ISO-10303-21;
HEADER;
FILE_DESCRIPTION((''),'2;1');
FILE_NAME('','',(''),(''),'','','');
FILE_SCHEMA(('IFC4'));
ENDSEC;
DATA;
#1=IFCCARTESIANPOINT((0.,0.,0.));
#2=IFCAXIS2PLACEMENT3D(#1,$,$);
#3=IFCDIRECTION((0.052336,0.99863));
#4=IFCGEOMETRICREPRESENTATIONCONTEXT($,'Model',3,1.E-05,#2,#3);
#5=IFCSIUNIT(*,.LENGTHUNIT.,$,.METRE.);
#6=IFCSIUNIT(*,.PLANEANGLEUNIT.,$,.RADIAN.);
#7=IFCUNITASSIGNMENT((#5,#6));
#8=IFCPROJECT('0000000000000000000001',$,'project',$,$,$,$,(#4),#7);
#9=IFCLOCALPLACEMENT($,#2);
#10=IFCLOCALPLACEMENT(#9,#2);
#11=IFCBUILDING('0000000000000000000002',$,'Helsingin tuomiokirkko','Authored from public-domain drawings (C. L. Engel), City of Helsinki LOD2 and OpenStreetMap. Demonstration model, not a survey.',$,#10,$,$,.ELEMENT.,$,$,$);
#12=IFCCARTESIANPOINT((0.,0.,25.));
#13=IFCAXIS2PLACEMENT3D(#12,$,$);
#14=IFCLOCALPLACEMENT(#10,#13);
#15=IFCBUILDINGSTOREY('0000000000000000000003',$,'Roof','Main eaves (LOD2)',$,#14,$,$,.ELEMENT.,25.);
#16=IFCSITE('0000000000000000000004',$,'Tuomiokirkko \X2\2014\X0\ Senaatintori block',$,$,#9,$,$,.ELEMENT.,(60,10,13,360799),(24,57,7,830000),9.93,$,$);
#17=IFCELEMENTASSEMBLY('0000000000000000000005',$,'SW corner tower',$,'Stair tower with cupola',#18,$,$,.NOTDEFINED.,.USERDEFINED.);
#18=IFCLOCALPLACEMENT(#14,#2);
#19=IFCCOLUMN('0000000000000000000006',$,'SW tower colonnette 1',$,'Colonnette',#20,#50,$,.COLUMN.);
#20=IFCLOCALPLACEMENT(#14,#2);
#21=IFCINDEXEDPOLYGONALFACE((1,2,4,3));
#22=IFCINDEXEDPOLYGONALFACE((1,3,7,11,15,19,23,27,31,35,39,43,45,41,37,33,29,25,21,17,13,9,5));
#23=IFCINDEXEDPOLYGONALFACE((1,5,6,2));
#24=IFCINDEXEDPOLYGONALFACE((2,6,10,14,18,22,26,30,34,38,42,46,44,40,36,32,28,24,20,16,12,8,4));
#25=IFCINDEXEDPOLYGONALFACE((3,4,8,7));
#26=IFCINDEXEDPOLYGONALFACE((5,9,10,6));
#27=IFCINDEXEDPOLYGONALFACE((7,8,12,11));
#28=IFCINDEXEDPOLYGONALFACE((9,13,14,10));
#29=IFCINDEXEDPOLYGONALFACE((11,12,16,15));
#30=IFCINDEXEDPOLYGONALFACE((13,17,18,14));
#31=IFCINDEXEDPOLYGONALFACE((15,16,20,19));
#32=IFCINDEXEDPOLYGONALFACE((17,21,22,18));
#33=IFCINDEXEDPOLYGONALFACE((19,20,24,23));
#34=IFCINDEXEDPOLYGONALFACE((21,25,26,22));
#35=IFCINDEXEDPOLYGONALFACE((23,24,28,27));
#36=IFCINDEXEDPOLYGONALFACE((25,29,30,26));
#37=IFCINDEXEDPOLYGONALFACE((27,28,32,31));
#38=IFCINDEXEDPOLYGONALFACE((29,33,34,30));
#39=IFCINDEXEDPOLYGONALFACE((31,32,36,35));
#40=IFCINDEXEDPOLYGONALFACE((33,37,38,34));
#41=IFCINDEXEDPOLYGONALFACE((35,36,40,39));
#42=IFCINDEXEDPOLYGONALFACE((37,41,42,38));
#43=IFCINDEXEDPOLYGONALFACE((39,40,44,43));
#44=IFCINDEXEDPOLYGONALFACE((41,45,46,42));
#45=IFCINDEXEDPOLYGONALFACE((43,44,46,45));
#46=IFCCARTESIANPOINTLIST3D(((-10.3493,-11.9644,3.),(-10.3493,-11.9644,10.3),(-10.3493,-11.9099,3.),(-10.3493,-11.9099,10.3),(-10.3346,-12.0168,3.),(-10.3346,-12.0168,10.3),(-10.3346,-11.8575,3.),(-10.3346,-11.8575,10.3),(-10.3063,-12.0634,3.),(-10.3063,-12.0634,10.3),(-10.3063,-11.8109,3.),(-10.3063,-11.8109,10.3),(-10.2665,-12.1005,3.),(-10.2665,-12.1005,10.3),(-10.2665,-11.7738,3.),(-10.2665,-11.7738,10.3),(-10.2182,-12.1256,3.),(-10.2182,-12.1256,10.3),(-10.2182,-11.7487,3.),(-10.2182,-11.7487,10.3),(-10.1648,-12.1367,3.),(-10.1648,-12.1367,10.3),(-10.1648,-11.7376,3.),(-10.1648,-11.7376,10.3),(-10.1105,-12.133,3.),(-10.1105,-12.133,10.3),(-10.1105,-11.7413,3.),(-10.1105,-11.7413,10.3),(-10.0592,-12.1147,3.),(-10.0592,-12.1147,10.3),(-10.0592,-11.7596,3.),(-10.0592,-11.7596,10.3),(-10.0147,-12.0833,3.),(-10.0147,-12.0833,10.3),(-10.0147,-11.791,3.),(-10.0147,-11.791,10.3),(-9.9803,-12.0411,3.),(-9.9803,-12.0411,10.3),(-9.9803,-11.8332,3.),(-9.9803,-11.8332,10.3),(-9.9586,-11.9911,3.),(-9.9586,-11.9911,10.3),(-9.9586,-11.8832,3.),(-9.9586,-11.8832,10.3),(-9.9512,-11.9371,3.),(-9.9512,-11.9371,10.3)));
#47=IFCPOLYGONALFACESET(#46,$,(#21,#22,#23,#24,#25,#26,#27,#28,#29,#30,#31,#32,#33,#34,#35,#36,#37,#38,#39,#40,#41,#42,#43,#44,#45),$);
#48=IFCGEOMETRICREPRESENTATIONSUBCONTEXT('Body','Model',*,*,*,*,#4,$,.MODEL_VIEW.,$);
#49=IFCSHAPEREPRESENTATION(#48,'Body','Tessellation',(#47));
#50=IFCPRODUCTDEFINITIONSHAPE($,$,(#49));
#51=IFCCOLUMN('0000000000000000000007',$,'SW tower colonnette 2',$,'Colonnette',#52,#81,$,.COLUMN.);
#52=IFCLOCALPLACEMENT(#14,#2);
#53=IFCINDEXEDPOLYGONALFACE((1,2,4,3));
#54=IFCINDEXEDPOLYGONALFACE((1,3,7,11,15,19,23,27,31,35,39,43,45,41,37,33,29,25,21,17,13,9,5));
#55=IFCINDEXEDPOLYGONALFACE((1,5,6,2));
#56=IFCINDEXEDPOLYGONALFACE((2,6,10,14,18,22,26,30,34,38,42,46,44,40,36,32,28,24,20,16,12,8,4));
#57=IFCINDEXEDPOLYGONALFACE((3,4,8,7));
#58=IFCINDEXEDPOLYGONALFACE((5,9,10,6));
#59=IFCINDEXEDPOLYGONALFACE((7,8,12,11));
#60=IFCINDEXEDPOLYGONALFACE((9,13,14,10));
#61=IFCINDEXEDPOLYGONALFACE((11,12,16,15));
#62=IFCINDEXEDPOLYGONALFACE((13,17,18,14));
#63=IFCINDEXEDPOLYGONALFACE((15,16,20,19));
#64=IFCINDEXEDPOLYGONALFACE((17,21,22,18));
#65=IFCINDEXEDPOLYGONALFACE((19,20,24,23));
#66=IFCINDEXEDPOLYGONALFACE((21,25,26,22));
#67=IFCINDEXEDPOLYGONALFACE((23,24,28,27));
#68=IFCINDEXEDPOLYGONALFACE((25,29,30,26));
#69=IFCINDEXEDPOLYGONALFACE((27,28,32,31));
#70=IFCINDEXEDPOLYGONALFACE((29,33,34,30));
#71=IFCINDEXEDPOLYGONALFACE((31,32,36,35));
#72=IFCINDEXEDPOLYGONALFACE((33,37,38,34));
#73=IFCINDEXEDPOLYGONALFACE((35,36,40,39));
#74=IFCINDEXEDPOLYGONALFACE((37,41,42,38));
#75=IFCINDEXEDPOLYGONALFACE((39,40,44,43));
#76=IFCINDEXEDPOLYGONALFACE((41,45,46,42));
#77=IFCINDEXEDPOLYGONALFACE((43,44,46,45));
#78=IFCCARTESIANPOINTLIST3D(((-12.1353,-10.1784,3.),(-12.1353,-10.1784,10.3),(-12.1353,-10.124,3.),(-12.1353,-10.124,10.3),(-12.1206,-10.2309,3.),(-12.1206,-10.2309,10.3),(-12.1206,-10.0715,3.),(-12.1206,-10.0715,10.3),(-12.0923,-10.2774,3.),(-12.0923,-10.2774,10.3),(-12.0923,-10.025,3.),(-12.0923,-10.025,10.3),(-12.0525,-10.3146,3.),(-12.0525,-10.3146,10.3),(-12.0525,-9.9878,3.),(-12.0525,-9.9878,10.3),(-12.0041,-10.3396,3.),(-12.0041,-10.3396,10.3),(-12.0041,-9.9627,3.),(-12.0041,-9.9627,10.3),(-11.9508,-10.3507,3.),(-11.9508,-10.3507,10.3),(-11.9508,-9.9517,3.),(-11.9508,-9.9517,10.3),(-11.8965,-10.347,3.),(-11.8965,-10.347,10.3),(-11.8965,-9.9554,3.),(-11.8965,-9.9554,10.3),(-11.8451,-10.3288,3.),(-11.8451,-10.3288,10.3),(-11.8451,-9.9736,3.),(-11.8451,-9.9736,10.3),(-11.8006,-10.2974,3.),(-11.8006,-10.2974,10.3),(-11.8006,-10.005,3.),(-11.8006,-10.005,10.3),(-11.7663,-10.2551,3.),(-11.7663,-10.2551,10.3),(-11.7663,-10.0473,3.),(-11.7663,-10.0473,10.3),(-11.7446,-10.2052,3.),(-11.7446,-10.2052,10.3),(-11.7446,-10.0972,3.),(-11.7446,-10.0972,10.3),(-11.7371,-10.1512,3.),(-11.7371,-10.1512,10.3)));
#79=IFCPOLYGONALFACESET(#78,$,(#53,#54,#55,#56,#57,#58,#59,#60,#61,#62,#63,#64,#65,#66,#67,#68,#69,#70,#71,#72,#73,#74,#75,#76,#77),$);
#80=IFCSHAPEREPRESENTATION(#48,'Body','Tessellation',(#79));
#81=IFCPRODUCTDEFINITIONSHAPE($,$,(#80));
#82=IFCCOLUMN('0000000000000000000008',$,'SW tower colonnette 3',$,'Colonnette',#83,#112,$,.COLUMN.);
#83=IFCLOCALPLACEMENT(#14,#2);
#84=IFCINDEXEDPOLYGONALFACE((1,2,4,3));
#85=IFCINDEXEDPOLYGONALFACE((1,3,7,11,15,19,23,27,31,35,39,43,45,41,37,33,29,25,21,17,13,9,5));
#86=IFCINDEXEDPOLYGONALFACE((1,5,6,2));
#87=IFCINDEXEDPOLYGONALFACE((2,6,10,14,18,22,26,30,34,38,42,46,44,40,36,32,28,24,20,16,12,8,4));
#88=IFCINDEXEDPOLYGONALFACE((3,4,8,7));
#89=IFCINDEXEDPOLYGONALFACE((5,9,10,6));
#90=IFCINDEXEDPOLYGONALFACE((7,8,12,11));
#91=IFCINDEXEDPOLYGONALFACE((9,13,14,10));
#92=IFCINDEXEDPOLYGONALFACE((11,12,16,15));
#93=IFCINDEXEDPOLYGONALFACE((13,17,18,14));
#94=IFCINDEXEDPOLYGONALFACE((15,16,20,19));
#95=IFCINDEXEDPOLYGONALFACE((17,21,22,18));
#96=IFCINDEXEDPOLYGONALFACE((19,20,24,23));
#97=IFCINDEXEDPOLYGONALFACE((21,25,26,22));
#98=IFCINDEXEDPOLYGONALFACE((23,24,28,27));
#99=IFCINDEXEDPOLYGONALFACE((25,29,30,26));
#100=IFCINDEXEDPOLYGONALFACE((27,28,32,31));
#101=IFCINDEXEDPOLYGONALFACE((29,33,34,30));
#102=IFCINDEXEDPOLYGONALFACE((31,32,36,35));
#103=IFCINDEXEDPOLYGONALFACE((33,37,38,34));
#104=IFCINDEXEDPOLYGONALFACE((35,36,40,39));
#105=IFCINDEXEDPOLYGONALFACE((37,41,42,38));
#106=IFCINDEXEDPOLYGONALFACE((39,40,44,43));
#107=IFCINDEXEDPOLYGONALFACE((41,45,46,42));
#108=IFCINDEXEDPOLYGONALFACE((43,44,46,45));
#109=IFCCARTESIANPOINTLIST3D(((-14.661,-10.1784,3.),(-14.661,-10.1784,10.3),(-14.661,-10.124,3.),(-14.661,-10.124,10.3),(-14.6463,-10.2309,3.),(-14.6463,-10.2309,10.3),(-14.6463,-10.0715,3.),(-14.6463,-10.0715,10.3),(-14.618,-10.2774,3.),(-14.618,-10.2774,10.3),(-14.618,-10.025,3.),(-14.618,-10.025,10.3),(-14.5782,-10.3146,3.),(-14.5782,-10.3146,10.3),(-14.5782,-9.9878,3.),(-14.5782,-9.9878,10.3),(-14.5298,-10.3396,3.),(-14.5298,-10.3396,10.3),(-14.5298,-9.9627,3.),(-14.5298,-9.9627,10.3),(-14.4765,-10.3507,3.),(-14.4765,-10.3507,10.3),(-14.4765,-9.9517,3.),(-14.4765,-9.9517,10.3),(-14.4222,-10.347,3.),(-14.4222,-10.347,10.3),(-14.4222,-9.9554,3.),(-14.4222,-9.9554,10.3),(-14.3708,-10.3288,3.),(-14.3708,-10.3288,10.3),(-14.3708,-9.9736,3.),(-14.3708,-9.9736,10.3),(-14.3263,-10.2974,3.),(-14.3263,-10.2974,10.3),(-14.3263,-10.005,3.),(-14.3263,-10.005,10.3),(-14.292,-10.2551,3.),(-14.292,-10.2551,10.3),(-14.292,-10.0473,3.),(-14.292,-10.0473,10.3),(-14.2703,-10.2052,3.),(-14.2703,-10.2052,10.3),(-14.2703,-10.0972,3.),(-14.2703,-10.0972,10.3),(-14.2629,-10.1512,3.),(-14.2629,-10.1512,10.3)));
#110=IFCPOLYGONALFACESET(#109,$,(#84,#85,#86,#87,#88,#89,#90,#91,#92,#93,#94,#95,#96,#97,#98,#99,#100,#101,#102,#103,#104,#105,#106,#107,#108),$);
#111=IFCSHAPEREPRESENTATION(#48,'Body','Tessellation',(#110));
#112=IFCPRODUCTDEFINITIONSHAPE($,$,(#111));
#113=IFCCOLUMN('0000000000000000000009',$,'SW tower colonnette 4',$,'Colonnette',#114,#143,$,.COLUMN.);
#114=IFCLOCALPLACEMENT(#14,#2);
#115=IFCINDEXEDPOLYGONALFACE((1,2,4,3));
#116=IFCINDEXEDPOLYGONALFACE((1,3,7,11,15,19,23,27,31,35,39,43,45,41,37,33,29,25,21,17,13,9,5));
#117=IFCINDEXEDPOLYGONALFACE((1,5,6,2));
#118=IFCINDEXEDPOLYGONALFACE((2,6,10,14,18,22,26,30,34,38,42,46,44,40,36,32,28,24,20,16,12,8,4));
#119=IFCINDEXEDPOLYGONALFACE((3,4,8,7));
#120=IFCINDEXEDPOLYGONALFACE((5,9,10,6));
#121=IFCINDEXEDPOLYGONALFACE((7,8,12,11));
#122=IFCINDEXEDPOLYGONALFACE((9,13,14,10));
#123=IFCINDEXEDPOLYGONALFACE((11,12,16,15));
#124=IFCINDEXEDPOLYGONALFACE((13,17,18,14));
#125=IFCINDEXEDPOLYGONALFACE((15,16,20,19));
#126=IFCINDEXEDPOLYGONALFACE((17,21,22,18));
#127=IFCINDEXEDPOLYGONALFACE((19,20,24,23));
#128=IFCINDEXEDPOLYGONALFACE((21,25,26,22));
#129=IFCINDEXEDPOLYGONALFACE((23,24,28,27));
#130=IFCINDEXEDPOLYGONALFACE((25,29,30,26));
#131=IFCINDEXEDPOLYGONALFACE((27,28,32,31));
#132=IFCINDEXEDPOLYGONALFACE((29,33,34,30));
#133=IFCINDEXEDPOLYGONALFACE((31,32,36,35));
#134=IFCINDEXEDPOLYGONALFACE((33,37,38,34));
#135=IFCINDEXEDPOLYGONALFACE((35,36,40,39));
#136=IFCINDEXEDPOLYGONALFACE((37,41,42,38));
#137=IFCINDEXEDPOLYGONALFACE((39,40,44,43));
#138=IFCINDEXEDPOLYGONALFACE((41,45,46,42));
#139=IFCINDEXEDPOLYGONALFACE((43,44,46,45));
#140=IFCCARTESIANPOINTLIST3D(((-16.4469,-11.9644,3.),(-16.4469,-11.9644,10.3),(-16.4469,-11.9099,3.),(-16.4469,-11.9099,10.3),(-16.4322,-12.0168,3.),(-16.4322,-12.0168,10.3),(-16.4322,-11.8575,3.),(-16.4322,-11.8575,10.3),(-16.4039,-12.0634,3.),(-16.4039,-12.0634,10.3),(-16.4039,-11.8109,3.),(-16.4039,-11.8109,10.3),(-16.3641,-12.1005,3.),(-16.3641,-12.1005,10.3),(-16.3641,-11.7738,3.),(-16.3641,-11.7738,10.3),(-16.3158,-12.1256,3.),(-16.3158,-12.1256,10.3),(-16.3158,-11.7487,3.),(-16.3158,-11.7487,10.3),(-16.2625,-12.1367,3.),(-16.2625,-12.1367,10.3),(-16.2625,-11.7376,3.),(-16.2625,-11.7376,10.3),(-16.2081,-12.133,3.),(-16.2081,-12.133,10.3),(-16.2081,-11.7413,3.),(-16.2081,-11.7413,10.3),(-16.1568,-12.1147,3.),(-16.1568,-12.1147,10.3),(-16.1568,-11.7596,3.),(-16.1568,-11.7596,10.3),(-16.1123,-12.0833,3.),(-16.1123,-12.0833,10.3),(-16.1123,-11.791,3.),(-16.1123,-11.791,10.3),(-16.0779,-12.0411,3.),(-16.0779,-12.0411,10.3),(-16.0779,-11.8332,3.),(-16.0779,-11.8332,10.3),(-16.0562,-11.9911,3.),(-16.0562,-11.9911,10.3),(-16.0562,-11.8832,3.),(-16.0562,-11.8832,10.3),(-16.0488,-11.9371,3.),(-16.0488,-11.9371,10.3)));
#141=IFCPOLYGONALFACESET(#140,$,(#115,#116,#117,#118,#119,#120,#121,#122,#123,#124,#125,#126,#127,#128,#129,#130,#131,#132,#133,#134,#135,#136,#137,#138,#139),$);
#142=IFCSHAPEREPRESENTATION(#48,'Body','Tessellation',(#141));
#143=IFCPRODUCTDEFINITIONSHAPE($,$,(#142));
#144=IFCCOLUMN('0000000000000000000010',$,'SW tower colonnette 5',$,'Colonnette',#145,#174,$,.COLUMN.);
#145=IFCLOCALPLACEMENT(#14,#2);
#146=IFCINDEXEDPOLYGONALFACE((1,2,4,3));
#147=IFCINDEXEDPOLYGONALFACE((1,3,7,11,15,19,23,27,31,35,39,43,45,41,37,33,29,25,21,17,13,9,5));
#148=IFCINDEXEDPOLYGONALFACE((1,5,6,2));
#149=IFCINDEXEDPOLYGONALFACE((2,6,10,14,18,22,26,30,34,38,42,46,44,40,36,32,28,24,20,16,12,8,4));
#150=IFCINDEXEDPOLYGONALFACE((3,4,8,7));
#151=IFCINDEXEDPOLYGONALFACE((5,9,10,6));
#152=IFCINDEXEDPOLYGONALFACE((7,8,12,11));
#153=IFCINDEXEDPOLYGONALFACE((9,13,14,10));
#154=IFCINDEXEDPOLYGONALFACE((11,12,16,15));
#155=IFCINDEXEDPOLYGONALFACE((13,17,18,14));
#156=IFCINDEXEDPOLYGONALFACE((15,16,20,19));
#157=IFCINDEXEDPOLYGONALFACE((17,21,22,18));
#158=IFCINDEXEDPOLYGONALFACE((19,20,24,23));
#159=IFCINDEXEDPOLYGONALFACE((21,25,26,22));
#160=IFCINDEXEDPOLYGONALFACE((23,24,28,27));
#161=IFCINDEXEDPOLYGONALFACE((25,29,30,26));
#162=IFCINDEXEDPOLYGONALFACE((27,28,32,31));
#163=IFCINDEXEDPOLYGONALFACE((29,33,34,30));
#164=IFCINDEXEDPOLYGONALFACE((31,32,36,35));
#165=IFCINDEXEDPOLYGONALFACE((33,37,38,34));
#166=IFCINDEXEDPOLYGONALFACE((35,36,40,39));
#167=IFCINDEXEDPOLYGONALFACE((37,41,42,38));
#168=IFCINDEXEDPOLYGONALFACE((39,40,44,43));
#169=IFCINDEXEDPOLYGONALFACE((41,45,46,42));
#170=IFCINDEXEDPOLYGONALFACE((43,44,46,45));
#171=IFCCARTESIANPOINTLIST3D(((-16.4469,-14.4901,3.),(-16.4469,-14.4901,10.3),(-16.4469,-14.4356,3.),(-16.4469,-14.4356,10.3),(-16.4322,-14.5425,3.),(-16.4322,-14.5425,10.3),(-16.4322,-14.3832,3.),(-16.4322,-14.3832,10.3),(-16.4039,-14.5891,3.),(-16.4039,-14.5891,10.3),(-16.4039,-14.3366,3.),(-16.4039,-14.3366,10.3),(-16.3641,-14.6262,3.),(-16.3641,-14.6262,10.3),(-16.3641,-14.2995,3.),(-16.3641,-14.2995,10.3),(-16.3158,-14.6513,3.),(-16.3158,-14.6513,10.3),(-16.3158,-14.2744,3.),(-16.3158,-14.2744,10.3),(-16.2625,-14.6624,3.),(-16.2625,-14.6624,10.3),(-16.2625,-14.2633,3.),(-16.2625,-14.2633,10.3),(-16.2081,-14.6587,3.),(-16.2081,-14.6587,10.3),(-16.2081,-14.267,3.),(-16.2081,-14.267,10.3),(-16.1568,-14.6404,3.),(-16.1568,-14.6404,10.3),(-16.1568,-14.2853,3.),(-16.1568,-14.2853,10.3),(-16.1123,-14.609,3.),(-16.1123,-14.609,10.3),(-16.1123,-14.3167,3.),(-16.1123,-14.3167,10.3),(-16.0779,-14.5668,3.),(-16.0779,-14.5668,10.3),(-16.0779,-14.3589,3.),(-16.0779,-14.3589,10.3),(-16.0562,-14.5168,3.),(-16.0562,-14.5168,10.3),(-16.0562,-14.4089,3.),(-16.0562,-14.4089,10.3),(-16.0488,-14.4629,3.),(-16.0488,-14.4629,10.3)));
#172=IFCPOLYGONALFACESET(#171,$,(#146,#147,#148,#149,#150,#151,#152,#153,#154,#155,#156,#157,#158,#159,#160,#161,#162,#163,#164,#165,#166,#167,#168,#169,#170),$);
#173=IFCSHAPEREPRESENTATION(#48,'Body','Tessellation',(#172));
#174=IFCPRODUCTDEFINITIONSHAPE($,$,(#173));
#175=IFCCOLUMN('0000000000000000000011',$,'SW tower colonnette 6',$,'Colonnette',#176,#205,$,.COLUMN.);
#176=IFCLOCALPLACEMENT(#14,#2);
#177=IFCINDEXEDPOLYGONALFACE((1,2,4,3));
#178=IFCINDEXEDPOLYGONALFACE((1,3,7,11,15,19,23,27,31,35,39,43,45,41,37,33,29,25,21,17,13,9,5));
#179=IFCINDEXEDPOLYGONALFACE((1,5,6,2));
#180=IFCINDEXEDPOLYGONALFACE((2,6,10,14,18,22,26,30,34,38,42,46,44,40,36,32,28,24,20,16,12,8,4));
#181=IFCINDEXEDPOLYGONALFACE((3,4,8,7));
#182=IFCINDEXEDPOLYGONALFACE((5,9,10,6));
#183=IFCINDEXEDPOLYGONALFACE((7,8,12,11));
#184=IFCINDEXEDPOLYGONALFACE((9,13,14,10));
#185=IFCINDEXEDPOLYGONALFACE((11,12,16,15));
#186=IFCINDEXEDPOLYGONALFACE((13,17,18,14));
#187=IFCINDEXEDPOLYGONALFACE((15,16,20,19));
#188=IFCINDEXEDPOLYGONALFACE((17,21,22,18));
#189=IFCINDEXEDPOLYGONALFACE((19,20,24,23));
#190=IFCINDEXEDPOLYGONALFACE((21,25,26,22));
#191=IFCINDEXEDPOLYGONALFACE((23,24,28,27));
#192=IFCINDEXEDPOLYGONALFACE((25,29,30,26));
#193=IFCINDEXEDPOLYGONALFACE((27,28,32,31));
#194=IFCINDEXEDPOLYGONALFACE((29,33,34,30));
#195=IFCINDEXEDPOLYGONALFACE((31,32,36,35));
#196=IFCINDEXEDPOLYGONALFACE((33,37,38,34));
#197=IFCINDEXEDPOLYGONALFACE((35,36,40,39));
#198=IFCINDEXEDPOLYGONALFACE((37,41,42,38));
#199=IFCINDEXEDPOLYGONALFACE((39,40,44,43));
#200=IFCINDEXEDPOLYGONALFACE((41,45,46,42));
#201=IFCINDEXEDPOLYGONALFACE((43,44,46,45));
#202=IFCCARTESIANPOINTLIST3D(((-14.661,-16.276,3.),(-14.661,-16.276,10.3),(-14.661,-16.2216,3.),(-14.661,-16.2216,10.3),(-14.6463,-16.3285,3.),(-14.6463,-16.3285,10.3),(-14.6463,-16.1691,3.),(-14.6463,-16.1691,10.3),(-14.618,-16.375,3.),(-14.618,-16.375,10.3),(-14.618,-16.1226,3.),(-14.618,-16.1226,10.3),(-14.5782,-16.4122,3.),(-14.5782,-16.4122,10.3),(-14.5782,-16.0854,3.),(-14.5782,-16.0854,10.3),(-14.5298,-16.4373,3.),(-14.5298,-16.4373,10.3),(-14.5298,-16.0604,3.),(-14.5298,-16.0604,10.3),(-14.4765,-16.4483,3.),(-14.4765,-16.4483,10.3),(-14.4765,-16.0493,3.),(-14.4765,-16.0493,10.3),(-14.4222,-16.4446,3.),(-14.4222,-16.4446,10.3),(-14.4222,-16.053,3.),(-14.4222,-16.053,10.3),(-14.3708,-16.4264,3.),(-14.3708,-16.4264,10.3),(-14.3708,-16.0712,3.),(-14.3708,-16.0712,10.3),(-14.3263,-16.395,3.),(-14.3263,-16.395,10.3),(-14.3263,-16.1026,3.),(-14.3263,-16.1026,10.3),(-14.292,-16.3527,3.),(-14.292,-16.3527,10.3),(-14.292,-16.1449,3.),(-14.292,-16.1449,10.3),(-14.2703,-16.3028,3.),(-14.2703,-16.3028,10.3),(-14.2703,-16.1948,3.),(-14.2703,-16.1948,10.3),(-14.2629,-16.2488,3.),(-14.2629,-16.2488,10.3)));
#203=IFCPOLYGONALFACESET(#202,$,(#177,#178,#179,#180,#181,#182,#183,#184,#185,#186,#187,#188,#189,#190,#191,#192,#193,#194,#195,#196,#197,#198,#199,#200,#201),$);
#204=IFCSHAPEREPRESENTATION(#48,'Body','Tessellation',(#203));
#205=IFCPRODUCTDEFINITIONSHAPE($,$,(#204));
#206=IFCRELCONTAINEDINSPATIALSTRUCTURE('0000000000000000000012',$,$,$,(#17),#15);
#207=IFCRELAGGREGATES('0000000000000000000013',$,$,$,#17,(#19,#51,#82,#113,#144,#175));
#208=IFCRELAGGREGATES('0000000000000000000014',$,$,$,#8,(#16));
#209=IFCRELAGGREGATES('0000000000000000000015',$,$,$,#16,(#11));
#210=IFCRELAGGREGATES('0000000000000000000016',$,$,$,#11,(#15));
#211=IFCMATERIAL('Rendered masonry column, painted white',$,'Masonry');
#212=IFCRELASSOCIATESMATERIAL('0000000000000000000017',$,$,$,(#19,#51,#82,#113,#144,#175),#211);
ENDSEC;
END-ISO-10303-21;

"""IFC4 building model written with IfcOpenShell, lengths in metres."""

from ifc_helpers import new_model, si_unit, direction, frame, origin, origin_2d_with_axis, place, context, subcontext, project, spatial, circle, extrude, material, element, aggregate, save


model = new_model("IFC4")

# Units and contexts
model_context = context("Model", 3, precision=1e-05, world=origin(), true_north=direction((0.052336, 0.99863)))
body_context = subcontext(model_context, "Body", "Model", "MODEL_VIEW")
ifc_project = project(units=[si_unit("LENGTHUNIT", "METRE"), si_unit("PLANEANGLEUNIT", "RADIAN")], contexts=[model_context])

# Site, building, storey
site_placement = place(None, origin())
site = spatial("IfcSite", under=ifc_project, at=site_placement, Name="Tuomiokirkko — Senaatintori block", CompositionType="ELEMENT", RefLatitude=(60, 10, 13, 360799), RefLongitude=(24, 57, 7, 830000), RefElevation=9.93)
building_placement = place(site_placement, origin())
building = spatial("IfcBuilding", under=site, at=building_placement, Name="Helsingin tuomiokirkko", Description="Authored from public-domain drawings (C. L. Engel), City of Helsinki LOD2 and OpenStreetMap. Demonstration model, not a survey.", CompositionType="ELEMENT")
storey_placement = place(building_placement, frame((0.0, 0.0, 25.0)))
storey = spatial("IfcBuildingStorey", under=building, at=storey_placement, Name="Roof", Description="Main eaves (LOD2)", CompositionType="ELEMENT", Elevation=25.0)

# Element assembly, columns
assembly_1_placement = place(building_placement, origin())
assembly_1 = element("IfcElementAssembly", 1, at=assembly_1_placement, inside=storey, Name="SW corner tower", ObjectType="Stair tower with cupola", AssemblyPlace="NOTDEFINED", PredefinedType="USERDEFINED")
ifc_material_1 = material(Name="Rendered masonry column, painted white", Category="Masonry")
column_1_placement = place(building_placement, origin())
column_1 = element("IfcColumn", 2, at=column_1_placement, material=ifc_material_1, Name="SW tower colonnette 1", ObjectType="Colonnette", PredefinedType="COLUMN", context=body_context, shape_type="SweptSolid", body=[
    extrude(circle(Radius=0.2, at=origin_2d_with_axis()), frame((-10.1512, -11.9371, 28.0)), (0.0, 0.0, 1.0), 7.3),
])
column_2_placement = place(building_placement, origin())
column_2 = element("IfcColumn", 3, at=column_2_placement, material=ifc_material_1, Name="SW tower colonnette 2", ObjectType="Colonnette", PredefinedType="COLUMN", context=body_context, shape_type="SweptSolid", body=[
    extrude(circle(Radius=0.2, at=origin_2d_with_axis()), frame((-11.9371, -10.1512, 28.0)), (0.0, 0.0, 1.0), 7.3),
])
column_3_placement = place(building_placement, origin())
column_3 = element("IfcColumn", 4, at=column_3_placement, material=ifc_material_1, Name="SW tower colonnette 3", ObjectType="Colonnette", PredefinedType="COLUMN", context=body_context, shape_type="SweptSolid", body=[
    extrude(circle(Radius=0.2, at=origin_2d_with_axis()), frame((-14.4629, -10.1512, 28.0)), (0.0, 0.0, 1.0), 7.3),
])
column_4_placement = place(building_placement, origin())
column_4 = element("IfcColumn", 5, at=column_4_placement, material=ifc_material_1, Name="SW tower colonnette 4", ObjectType="Colonnette", PredefinedType="COLUMN", context=body_context, shape_type="SweptSolid", body=[
    extrude(circle(Radius=0.2, at=origin_2d_with_axis()), frame((-16.2488, -11.9371, 28.0)), (0.0, 0.0, 1.0), 7.3),
])
column_5_placement = place(building_placement, origin())
column_5 = element("IfcColumn", 6, at=column_5_placement, material=ifc_material_1, Name="SW tower colonnette 5", ObjectType="Colonnette", PredefinedType="COLUMN", context=body_context, shape_type="SweptSolid", body=[
    extrude(circle(Radius=0.2, at=origin_2d_with_axis()), frame((-16.2488, -14.4629, 28.0)), (0.0, 0.0, 1.0), 7.3),
])
column_6_placement = place(building_placement, origin())
column_6 = element("IfcColumn", 7, at=column_6_placement, material=ifc_material_1, Name="SW tower colonnette 6", ObjectType="Colonnette", PredefinedType="COLUMN", context=body_context, shape_type="SweptSolid", body=[
    extrude(circle(Radius=0.2, at=origin_2d_with_axis()), frame((-14.4629, -16.2488, 28.0)), (0.0, 0.0, 1.0), 7.3),
])

aggregate(assembly_1, [column_1, column_2, column_3, column_4, column_5, column_6])

save(model, "model.ifc")
